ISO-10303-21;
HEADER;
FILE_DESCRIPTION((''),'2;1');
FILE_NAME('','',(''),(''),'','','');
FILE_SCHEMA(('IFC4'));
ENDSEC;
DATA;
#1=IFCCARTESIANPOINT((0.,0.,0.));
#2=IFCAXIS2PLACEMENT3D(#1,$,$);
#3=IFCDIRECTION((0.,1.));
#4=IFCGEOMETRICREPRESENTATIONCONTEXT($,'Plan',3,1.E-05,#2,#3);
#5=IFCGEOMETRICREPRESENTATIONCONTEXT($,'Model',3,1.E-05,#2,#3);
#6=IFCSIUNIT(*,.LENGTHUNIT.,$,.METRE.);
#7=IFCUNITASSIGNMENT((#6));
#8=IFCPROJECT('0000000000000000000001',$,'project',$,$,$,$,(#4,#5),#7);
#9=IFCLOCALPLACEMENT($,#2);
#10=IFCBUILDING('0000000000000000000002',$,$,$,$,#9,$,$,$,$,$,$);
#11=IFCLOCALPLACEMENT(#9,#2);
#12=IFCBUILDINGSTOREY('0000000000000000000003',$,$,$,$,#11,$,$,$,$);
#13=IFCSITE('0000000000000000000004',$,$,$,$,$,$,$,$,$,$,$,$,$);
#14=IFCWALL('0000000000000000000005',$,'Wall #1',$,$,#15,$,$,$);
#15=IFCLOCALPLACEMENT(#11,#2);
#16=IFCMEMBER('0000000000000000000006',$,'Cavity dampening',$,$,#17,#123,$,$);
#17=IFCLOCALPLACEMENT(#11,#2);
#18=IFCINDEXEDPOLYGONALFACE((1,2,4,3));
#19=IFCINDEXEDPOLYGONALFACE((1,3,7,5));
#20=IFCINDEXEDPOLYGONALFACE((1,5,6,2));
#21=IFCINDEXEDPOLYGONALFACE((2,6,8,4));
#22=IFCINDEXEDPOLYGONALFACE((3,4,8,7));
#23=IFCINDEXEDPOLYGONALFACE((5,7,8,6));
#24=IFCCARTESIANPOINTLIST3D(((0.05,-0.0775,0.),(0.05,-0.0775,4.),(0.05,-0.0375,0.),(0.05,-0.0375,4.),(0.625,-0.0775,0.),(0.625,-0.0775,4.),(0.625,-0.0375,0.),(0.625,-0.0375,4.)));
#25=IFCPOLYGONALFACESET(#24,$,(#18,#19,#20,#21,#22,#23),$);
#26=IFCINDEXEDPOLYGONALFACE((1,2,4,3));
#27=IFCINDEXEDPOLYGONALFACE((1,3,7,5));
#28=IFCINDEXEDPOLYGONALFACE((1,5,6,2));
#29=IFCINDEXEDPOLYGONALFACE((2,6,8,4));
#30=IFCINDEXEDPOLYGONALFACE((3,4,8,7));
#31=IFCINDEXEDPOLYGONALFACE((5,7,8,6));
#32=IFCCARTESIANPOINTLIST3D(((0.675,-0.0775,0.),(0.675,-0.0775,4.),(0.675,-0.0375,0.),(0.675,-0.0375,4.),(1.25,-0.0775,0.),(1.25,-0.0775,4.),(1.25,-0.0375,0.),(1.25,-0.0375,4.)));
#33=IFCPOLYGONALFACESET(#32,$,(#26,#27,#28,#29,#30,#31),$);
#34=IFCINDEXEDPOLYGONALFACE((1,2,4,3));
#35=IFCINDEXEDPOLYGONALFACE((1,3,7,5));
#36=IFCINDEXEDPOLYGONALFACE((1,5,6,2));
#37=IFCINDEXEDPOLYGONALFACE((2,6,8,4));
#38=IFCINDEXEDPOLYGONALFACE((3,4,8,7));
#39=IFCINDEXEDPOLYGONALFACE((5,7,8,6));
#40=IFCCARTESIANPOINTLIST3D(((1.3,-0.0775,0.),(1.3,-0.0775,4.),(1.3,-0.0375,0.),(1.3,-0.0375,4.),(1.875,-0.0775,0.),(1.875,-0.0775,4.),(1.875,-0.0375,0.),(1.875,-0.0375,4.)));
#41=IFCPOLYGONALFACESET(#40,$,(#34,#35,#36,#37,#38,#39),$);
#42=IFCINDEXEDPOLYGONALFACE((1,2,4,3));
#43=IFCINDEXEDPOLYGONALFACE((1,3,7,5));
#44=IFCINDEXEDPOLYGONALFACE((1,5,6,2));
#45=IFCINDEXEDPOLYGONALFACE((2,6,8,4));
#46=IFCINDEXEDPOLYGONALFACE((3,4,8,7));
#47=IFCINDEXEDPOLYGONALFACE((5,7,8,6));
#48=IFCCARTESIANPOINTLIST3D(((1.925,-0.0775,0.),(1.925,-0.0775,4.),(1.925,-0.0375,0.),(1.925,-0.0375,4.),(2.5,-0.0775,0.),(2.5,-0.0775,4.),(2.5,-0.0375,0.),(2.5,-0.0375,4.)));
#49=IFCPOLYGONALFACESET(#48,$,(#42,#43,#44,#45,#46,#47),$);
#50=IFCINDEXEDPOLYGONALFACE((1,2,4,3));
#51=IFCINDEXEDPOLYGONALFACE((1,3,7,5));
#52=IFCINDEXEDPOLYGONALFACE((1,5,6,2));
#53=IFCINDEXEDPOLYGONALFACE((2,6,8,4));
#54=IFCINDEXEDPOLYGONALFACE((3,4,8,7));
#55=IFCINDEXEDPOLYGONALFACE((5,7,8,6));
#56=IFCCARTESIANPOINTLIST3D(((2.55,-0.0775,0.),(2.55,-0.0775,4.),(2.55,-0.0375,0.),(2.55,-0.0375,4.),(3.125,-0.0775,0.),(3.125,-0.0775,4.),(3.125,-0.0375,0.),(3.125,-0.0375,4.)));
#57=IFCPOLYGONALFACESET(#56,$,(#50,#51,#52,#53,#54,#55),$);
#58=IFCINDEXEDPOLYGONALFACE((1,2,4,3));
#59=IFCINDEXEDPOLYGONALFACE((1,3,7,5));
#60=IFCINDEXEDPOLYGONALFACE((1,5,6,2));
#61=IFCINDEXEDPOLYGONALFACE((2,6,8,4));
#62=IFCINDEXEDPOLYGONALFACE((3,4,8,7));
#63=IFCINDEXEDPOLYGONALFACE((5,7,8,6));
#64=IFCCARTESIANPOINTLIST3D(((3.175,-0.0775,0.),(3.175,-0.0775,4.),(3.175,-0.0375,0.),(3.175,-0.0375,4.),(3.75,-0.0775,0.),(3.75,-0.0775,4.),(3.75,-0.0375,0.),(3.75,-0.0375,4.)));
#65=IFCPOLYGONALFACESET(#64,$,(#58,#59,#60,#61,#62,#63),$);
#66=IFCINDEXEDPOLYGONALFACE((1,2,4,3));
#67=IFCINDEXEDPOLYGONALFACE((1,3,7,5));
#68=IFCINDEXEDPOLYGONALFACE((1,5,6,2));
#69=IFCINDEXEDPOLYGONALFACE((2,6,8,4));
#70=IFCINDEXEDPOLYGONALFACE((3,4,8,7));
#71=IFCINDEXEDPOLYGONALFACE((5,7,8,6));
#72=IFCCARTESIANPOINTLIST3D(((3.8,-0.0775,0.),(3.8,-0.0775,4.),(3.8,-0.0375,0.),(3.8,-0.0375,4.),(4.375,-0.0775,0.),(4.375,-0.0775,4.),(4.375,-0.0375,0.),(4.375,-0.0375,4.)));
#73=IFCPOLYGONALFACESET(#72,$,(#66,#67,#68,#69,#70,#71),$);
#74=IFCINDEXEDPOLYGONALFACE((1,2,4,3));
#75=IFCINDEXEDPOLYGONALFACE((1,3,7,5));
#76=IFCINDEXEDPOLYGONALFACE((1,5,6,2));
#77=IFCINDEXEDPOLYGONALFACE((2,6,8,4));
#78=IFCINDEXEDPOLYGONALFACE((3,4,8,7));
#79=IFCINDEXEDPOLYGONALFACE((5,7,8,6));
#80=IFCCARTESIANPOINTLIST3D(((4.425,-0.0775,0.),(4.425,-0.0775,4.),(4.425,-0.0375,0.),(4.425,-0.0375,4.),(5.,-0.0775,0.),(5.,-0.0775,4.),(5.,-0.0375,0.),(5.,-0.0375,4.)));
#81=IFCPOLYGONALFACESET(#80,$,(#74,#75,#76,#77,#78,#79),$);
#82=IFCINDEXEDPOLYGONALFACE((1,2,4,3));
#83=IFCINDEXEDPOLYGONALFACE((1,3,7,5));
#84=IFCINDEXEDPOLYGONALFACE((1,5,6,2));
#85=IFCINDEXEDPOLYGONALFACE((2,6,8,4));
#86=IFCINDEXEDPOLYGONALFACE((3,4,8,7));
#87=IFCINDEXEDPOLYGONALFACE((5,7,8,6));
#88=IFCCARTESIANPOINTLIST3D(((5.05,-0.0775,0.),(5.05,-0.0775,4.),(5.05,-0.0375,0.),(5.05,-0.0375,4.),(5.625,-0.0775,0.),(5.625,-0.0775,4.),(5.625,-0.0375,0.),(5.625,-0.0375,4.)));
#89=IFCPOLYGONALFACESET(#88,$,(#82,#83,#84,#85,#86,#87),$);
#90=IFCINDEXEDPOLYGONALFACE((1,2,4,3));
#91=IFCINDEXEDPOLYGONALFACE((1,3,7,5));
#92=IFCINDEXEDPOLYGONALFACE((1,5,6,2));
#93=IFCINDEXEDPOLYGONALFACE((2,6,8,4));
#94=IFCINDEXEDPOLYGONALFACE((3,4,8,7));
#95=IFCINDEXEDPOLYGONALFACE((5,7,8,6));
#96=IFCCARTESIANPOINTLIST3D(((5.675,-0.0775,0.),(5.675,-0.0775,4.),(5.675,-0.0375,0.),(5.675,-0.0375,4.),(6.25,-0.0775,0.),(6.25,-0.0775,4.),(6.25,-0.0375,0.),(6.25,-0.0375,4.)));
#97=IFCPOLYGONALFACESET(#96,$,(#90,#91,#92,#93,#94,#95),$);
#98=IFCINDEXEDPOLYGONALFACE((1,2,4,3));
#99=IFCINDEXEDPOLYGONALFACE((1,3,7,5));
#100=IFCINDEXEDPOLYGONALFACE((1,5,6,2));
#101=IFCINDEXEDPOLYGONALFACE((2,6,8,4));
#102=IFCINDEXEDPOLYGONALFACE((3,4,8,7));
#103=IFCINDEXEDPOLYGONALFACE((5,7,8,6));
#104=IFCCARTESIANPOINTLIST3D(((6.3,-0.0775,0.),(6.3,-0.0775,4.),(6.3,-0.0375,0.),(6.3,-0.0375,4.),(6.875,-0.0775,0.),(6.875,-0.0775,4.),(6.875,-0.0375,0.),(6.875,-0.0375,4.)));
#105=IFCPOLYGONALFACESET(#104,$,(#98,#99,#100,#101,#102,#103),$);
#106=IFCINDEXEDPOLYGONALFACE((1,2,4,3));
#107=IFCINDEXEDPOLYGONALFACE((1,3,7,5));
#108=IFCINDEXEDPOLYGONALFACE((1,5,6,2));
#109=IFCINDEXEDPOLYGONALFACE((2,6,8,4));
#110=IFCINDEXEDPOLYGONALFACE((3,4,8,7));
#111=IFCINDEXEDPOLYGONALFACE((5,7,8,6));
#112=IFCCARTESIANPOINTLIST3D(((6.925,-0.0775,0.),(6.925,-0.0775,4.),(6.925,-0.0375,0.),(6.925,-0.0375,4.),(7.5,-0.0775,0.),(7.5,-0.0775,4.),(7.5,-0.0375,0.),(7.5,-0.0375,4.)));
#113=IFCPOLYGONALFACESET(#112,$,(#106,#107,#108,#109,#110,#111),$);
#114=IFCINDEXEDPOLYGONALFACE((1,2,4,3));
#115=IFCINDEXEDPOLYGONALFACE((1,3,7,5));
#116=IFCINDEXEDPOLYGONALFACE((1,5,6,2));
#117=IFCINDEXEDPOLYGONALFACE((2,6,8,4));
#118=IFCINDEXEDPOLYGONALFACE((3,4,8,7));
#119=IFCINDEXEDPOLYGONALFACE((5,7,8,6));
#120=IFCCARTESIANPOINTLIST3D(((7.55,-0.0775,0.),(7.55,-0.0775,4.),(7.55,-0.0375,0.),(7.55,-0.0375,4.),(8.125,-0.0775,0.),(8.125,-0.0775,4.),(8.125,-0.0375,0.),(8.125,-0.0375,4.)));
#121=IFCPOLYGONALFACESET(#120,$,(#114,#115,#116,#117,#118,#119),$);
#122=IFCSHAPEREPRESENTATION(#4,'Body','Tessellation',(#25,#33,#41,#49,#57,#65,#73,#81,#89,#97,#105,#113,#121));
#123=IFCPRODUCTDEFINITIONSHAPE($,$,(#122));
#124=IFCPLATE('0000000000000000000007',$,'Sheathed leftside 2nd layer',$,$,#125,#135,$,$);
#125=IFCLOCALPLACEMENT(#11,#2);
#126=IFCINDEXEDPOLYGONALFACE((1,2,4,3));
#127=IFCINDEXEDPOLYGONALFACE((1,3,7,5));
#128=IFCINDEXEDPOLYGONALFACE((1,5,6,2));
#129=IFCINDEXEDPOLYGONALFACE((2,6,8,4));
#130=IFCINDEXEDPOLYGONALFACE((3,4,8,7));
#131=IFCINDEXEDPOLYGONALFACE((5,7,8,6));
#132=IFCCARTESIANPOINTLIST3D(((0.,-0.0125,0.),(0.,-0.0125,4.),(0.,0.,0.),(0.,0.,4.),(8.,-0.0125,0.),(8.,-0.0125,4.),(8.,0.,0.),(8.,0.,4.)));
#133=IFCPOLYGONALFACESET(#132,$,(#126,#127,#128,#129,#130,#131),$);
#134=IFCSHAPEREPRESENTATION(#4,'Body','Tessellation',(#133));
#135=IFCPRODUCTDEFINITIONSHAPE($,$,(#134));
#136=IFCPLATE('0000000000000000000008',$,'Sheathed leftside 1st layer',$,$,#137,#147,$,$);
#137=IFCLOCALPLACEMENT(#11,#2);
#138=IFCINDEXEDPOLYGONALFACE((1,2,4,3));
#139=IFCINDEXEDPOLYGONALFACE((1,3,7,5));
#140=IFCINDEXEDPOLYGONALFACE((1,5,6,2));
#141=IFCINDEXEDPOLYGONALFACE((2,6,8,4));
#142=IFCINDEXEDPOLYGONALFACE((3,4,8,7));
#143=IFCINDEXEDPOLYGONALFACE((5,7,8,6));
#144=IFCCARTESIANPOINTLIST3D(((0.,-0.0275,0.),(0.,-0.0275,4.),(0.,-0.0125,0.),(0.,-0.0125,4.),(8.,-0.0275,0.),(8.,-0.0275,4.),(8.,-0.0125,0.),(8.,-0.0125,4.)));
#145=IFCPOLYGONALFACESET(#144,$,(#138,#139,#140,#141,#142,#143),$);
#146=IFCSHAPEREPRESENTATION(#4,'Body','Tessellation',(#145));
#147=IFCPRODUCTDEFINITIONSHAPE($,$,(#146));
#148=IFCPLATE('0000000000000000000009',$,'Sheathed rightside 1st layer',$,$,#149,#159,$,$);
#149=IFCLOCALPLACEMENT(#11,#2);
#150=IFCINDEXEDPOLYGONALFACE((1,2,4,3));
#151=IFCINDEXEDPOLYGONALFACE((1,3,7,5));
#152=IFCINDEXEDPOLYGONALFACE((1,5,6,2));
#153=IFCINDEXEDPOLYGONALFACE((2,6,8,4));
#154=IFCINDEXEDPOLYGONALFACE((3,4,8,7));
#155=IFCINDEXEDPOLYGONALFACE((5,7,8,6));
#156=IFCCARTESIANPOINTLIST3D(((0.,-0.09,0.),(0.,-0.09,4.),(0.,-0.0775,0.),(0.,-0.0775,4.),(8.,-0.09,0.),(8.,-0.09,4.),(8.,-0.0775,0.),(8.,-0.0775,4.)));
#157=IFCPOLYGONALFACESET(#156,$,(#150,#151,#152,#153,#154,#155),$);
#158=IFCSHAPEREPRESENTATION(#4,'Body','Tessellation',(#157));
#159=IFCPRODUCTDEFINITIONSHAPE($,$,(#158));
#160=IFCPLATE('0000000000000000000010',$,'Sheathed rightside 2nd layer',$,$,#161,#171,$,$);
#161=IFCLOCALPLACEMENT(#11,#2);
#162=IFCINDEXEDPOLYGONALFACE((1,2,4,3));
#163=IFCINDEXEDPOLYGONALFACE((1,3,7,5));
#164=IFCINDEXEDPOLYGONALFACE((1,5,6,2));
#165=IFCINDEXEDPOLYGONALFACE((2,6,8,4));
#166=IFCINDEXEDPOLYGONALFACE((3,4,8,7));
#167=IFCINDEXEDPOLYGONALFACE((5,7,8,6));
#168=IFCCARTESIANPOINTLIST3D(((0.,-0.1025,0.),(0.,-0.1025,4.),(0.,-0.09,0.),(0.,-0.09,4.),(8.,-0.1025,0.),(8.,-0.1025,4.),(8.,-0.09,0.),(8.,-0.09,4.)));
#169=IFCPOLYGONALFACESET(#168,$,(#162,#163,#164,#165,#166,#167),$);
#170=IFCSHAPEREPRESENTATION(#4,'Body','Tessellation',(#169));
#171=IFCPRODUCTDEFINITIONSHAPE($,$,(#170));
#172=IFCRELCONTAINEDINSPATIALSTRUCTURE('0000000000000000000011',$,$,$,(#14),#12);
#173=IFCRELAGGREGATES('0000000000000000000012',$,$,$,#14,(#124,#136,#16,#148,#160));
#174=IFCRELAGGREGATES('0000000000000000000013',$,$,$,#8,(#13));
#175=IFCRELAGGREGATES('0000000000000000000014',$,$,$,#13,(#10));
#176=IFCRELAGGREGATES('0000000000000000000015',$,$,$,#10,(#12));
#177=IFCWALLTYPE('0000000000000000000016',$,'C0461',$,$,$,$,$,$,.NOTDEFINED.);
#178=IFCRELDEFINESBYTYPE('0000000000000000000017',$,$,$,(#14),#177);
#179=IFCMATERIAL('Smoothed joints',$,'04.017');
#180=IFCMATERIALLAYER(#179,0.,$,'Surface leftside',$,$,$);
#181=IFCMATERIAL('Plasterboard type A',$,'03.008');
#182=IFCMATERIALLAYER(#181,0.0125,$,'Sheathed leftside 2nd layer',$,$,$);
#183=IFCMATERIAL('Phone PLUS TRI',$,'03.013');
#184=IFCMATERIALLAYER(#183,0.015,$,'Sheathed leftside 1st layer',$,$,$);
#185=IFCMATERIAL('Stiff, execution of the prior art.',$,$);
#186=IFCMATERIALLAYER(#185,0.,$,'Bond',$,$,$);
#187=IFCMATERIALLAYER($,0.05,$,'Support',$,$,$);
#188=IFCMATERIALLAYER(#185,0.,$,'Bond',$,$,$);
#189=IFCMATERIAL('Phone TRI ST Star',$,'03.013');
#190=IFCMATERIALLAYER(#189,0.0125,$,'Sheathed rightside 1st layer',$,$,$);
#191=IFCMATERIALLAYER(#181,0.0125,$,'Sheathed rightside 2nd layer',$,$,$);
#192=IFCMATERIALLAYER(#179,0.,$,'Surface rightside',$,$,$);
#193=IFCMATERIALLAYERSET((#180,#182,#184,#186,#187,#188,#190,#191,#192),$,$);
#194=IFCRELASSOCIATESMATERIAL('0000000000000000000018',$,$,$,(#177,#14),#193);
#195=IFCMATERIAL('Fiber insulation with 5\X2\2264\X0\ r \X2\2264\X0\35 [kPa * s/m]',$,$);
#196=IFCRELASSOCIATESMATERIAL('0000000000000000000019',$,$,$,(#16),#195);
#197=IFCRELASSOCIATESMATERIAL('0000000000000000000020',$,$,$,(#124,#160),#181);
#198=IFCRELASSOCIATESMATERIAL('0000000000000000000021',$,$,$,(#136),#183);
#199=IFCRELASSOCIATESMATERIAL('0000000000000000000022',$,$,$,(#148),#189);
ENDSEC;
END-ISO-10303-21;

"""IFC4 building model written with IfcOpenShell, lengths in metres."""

from ifc_helpers import new_model, si_unit, direction, frame, frame_2d, origin, origin_with_axes, place, context, project, spatial, rectangle, extrude, material, layer, layer_set, type_object, element, aggregate, save


model = new_model("IFC4")

# Units and contexts
plan_context = context("Plan", 3, precision=1e-05, world=origin(), true_north=direction((0.0, 1.0)))
model_context = context("Model", 3, precision=1e-05, world=origin(), true_north=direction((0.0, 1.0)))
ifc_project = project(units=[si_unit("LENGTHUNIT", "METRE")], contexts=[plan_context, model_context])

# Site, building, storey
site = spatial("IfcSite", under=ifc_project)
building_placement = place(None, origin())
building = spatial("IfcBuilding", under=site, at=building_placement)
storey_placement = place(building_placement, origin())
storey = spatial("IfcBuildingStorey", under=building, at=storey_placement)

# Wall, member, plates
ifc_material_1 = material(Name="Smoothed joints", Category="04.017")
ifc_layer_1 = layer(ifc_material_1, 0.0, Name="Surface leftside")
ifc_material_2 = material(Name="Plasterboard type A", Category="03.008")
ifc_layer_2 = layer(ifc_material_2, 0.0125, Name="Sheathed leftside 2nd layer")
ifc_material_3 = material(Name="Phone PLUS TRI", Category="03.013")
ifc_layer_3 = layer(ifc_material_3, 0.015, Name="Sheathed leftside 1st layer")
ifc_material_4 = material(Name="Stiff, execution of the prior art.")
ifc_layer_4 = layer(ifc_material_4, 0.0, Name="Bond")
ifc_layer_5 = layer(None, 0.05, Name="Support")
ifc_layer_6 = layer(ifc_material_4, 0.0, Name="Bond")
ifc_material_5 = material(Name="Phone TRI ST Star", Category="03.013")
ifc_layer_7 = layer(ifc_material_5, 0.0125, Name="Sheathed rightside 1st layer")
ifc_layer_8 = layer(ifc_material_2, 0.0125, Name="Sheathed rightside 2nd layer")
ifc_layer_9 = layer(ifc_material_1, 0.0, Name="Surface rightside")
ifc_layer_set = layer_set([ifc_layer_1, ifc_layer_2, ifc_layer_3, ifc_layer_4, ifc_layer_5, ifc_layer_6, ifc_layer_7, ifc_layer_8, ifc_layer_9])
wall_type = type_object("IfcWallType", Name="C0461", PredefinedType="NOTDEFINED", material=ifc_layer_set)
wall_placement = place(None, frame((0.0, 0.0, 0.0), z_axis=(0.0, -1.0, 0.0), x_axis=(1.0, 0.0, 0.0)))
wall = element("IfcWall", 1, at=wall_placement, inside=storey, type_object=wall_type, material=ifc_layer_set, Name="Wall #1")
ifc_material_6 = material(Name="Fiber insulation with 5≤ r ≤35 [kPa * s/m]")
member_1_placement = place(wall_placement, origin())
member_1 = element("IfcMember", 2, at=member_1_placement, material=ifc_material_6, Name="Cavity dampening", context=plan_context, shape_type="SweptSolid", body=[
    extrude(rectangle(XDim=0.575, YDim=0.04, at=frame_2d((0.2875, 0.02), x_axis=(1.0, 0.0))), frame((0.05, 4.0, 0.0375), z_axis=(0.0, -1.0, 0.0), x_axis=(1.0, 0.0, 0.0)), (0.0, 0.0, 1.0), 4.0),
    extrude(rectangle(XDim=0.575, YDim=0.04, at=frame_2d((0.2875, 0.02), x_axis=(1.0, 0.0))), frame((0.675, 4.0, 0.0375), z_axis=(0.0, -1.0, 0.0), x_axis=(1.0, 0.0, 0.0)), (0.0, 0.0, 1.0), 4.0),
    extrude(rectangle(XDim=0.575, YDim=0.04, at=frame_2d((0.2875, 0.02), x_axis=(1.0, 0.0))), frame((1.3, 4.0, 0.0375), z_axis=(0.0, -1.0, 0.0), x_axis=(1.0, 0.0, 0.0)), (0.0, 0.0, 1.0), 4.0),
    extrude(rectangle(XDim=0.575, YDim=0.04, at=frame_2d((0.2875, 0.02), x_axis=(1.0, 0.0))), frame((1.925, 4.0, 0.0375), z_axis=(0.0, -1.0, 0.0), x_axis=(1.0, 0.0, 0.0)), (0.0, 0.0, 1.0), 4.0),
    extrude(rectangle(XDim=0.575, YDim=0.04, at=frame_2d((0.2875, 0.02), x_axis=(1.0, 0.0))), frame((2.55, 4.0, 0.0375), z_axis=(0.0, -1.0, 0.0), x_axis=(1.0, 0.0, 0.0)), (0.0, 0.0, 1.0), 4.0),
    extrude(rectangle(XDim=0.575, YDim=0.04, at=frame_2d((0.2875, 0.02), x_axis=(1.0, 0.0))), frame((3.175, 4.0, 0.0375), z_axis=(0.0, -1.0, 0.0), x_axis=(1.0, 0.0, 0.0)), (0.0, 0.0, 1.0), 4.0),
    extrude(rectangle(XDim=0.575, YDim=0.04, at=frame_2d((0.2875, 0.02), x_axis=(1.0, 0.0))), frame((3.8, 4.0, 0.0375), z_axis=(0.0, -1.0, 0.0), x_axis=(1.0, 0.0, 0.0)), (0.0, 0.0, 1.0), 4.0),
    extrude(rectangle(XDim=0.575, YDim=0.04, at=frame_2d((0.2875, 0.02), x_axis=(1.0, 0.0))), frame((4.425, 4.0, 0.0375), z_axis=(0.0, -1.0, 0.0), x_axis=(1.0, 0.0, 0.0)), (0.0, 0.0, 1.0), 4.0),
    extrude(rectangle(XDim=0.575, YDim=0.04, at=frame_2d((0.2875, 0.02), x_axis=(1.0, 0.0))), frame((5.05, 4.0, 0.0375), z_axis=(0.0, -1.0, 0.0), x_axis=(1.0, 0.0, 0.0)), (0.0, 0.0, 1.0), 4.0),
    extrude(rectangle(XDim=0.575, YDim=0.04, at=frame_2d((0.2875, 0.02), x_axis=(1.0, 0.0))), frame((5.675, 4.0, 0.0375), z_axis=(0.0, -1.0, 0.0), x_axis=(1.0, 0.0, 0.0)), (0.0, 0.0, 1.0), 4.0),
    extrude(rectangle(XDim=0.575, YDim=0.04, at=frame_2d((0.2875, 0.02), x_axis=(1.0, 0.0))), frame((6.3, 4.0, 0.0375), z_axis=(0.0, -1.0, 0.0), x_axis=(1.0, 0.0, 0.0)), (0.0, 0.0, 1.0), 4.0),
    extrude(rectangle(XDim=0.575, YDim=0.04, at=frame_2d((0.2875, 0.02), x_axis=(1.0, 0.0))), frame((6.925, 4.0, 0.0375), z_axis=(0.0, -1.0, 0.0), x_axis=(1.0, 0.0, 0.0)), (0.0, 0.0, 1.0), 4.0),
    extrude(rectangle(XDim=0.575, YDim=0.04, at=frame_2d((0.2875, 0.02), x_axis=(1.0, 0.0))), frame((7.55, 4.0, 0.0375), z_axis=(0.0, -1.0, 0.0), x_axis=(1.0, 0.0, 0.0)), (0.0, 0.0, 1.0), 4.0),
])
plate_1_placement = place(wall_placement, origin())
plate_1 = element("IfcPlate", 3, at=plate_1_placement, material=ifc_material_2, Name="Sheathed leftside 2nd layer", context=plan_context, shape_type="SweptSolid", body=[
    extrude(rectangle(XDim=8.0, YDim=4.0, at=frame_2d((4.0, 2.0), x_axis=(1.0, 0.0))), origin_with_axes(), (0.0, 0.0, 1.0), 0.0125),
])
plate_2_placement = place(wall_placement, origin())
plate_2 = element("IfcPlate", 4, at=plate_2_placement, material=ifc_material_3, Name="Sheathed leftside 1st layer", context=plan_context, shape_type="SweptSolid", body=[
    extrude(rectangle(XDim=8.0, YDim=4.0, at=frame_2d((4.0, 2.0), x_axis=(1.0, 0.0))), frame((0.0, 0.0, 0.0125), z_axis=(0.0, 0.0, 1.0), x_axis=(1.0, 0.0, 0.0)), (0.0, 0.0, 1.0), 0.015),
])
plate_3_placement = place(wall_placement, origin())
plate_3 = element("IfcPlate", 5, at=plate_3_placement, material=ifc_material_5, Name="Sheathed rightside 1st layer", context=plan_context, shape_type="SweptSolid", body=[
    extrude(rectangle(XDim=8.0, YDim=4.0, at=frame_2d((4.0, 2.0), x_axis=(1.0, 0.0))), frame((0.0, 0.0, 0.0775), z_axis=(0.0, 0.0, 1.0), x_axis=(1.0, 0.0, 0.0)), (0.0, 0.0, 1.0), 0.0125),
])
plate_4_placement = place(wall_placement, origin())
plate_4 = element("IfcPlate", 6, at=plate_4_placement, material=ifc_material_2, Name="Sheathed rightside 2nd layer", context=plan_context, shape_type="SweptSolid", body=[
    extrude(rectangle(XDim=8.0, YDim=4.0, at=frame_2d((4.0, 2.0), x_axis=(1.0, 0.0))), frame((0.0, 0.0, 0.09), z_axis=(0.0, 0.0, 1.0), x_axis=(1.0, 0.0, 0.0)), (0.0, 0.0, 1.0), 0.0125),
])
aggregate(wall, [plate_1, plate_2, member_1, plate_3, plate_4])

save(model, "model.ifc")
